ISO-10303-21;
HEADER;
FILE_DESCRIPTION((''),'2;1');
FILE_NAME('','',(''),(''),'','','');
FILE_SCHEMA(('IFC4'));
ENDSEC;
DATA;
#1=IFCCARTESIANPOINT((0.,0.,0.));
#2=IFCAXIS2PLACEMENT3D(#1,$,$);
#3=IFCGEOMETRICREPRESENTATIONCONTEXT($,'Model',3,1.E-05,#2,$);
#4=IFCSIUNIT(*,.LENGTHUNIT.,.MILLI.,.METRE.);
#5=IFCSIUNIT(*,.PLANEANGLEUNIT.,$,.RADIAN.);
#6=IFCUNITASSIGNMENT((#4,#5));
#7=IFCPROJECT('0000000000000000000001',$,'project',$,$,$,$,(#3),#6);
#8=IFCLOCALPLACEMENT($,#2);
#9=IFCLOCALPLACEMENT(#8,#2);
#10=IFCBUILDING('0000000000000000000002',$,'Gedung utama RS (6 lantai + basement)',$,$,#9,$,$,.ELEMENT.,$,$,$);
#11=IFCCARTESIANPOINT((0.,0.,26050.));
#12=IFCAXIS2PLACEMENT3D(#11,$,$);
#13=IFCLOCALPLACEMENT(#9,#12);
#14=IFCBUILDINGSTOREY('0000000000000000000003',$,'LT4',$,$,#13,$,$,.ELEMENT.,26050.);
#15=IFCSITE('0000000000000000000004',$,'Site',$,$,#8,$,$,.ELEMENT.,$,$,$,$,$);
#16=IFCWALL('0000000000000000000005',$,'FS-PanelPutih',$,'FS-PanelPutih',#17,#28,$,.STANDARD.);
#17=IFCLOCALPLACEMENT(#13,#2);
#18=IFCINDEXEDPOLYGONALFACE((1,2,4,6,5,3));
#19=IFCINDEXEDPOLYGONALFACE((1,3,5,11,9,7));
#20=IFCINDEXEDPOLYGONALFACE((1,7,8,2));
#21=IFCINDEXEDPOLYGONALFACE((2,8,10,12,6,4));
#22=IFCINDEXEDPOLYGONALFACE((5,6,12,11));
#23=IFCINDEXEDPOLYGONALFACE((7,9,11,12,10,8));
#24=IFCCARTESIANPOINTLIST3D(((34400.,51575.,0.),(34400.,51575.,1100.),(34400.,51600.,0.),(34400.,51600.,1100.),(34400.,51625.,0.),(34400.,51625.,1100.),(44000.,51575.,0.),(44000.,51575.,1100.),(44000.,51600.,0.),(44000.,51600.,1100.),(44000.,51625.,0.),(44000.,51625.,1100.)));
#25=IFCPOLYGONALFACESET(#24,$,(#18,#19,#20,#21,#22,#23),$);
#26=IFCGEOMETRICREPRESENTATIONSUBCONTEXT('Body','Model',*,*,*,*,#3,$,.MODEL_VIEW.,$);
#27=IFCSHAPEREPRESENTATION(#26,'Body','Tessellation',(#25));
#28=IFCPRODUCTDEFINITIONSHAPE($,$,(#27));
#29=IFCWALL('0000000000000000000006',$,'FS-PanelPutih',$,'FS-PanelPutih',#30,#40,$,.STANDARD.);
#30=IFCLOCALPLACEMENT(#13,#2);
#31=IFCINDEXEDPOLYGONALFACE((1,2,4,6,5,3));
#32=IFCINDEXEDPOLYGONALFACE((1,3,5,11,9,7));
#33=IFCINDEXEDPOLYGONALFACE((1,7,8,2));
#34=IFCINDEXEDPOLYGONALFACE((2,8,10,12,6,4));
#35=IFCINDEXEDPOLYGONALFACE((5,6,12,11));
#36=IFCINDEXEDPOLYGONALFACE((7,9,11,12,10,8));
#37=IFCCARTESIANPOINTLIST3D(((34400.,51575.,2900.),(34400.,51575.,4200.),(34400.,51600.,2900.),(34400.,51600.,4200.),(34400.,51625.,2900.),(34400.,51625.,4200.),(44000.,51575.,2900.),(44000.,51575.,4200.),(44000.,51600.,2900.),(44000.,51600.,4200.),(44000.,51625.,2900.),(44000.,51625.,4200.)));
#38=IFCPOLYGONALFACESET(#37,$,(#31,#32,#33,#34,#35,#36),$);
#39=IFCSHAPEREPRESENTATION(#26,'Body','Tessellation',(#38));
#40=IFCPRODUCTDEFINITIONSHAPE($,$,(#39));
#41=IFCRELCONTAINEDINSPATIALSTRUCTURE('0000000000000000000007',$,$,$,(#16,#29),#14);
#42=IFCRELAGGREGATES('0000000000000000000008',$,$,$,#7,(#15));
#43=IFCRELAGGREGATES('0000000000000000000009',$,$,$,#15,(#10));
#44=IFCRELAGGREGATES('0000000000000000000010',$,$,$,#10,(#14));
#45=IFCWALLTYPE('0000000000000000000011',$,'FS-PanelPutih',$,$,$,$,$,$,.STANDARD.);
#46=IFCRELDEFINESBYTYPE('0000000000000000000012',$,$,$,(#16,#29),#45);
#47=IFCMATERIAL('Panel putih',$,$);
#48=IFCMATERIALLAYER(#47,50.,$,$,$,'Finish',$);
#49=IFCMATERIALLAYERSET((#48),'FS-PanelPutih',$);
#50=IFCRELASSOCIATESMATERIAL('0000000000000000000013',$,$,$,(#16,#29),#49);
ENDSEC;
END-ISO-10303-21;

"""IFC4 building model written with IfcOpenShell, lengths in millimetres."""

from ifc_helpers import new_model, si_unit, frame, origin, place, context, subcontext, project, spatial, polyline, outline, extrude, material, layer, layer_set, layer_usage, type_object, element, save


model = new_model("IFC4")

# Units and contexts
model_context = context("Model", 3, precision=1e-05, world=origin())
body_context = subcontext(model_context, "Body", "Model", "MODEL_VIEW")
ifc_project = project(units=[si_unit("LENGTHUNIT", "METRE", prefix="MILLI"), si_unit("PLANEANGLEUNIT", "RADIAN")], contexts=[model_context])

# Site, building, storey
site_placement = place(None, origin())
site = spatial("IfcSite", under=ifc_project, at=site_placement, Name="Site", CompositionType="ELEMENT")
building_placement = place(site_placement, origin())
building = spatial("IfcBuilding", under=site, at=building_placement, Name="Gedung utama RS (6 lantai + basement)", CompositionType="ELEMENT")
storey_placement = place(building_placement, frame((0.0, 0.0, 26050.0)))
storey = spatial("IfcBuildingStorey", under=building, at=storey_placement, Name="LT4", CompositionType="ELEMENT", Elevation=26050.0)

# Walls
ifc_material_1 = material(Name="Panel putih")
ifc_layer_1 = layer(ifc_material_1, 50.0, Category="Finish")
ifc_layer_set_1 = layer_set([ifc_layer_1], Name="FS-PanelPutih")
ifc_layer_usage_1 = layer_usage(ifc_layer_set_1, "AXIS2", "NEGATIVE", 25.0)
wall_type_1 = type_object("IfcWallType", Name="FS-PanelPutih", PredefinedType="STANDARD")
wall_1_placement = place(storey_placement, frame((34400.0, 51600.0, 0.0), z_axis=(0.0, 0.0, 1.0), x_axis=(1.0, 0.0, 0.0)))
element("IfcWall", 1, at=wall_1_placement, inside=storey, type_object=wall_type_1, material=ifc_layer_usage_1, Name="FS-PanelPutih", ObjectType="FS-PanelPutih", PredefinedType="STANDARD", context=body_context, shape_type="SweptSolid", body=[
    extrude(outline(polyline([(0.0, -25.0), (0.0, 0.0), (0.0, 25.0), (9600.0, 25.0), (9600.0, 0.0), (9600.0, -25.0), (0.0, -25.0)])), origin(), (0.0, 0.0, 1.0), 1100.0),
])
wall_2_placement = place(storey_placement, frame((34400.0, 51600.0, 2900.0), z_axis=(0.0, 0.0, 1.0), x_axis=(1.0, 0.0, 0.0)))
element("IfcWall", 2, at=wall_2_placement, inside=storey, type_object=wall_type_1, material=ifc_layer_usage_1, Name="FS-PanelPutih", ObjectType="FS-PanelPutih", PredefinedType="STANDARD", context=body_context, shape_type="SweptSolid", body=[
    extrude(outline(polyline([(0.0, -25.0), (0.0, 0.0), (0.0, 25.0), (9600.0, 25.0), (9600.0, 0.0), (9600.0, -25.0), (0.0, -25.0)])), origin(), (0.0, 0.0, 1.0), 1300.0),
])

save(model, "model.ifc")
